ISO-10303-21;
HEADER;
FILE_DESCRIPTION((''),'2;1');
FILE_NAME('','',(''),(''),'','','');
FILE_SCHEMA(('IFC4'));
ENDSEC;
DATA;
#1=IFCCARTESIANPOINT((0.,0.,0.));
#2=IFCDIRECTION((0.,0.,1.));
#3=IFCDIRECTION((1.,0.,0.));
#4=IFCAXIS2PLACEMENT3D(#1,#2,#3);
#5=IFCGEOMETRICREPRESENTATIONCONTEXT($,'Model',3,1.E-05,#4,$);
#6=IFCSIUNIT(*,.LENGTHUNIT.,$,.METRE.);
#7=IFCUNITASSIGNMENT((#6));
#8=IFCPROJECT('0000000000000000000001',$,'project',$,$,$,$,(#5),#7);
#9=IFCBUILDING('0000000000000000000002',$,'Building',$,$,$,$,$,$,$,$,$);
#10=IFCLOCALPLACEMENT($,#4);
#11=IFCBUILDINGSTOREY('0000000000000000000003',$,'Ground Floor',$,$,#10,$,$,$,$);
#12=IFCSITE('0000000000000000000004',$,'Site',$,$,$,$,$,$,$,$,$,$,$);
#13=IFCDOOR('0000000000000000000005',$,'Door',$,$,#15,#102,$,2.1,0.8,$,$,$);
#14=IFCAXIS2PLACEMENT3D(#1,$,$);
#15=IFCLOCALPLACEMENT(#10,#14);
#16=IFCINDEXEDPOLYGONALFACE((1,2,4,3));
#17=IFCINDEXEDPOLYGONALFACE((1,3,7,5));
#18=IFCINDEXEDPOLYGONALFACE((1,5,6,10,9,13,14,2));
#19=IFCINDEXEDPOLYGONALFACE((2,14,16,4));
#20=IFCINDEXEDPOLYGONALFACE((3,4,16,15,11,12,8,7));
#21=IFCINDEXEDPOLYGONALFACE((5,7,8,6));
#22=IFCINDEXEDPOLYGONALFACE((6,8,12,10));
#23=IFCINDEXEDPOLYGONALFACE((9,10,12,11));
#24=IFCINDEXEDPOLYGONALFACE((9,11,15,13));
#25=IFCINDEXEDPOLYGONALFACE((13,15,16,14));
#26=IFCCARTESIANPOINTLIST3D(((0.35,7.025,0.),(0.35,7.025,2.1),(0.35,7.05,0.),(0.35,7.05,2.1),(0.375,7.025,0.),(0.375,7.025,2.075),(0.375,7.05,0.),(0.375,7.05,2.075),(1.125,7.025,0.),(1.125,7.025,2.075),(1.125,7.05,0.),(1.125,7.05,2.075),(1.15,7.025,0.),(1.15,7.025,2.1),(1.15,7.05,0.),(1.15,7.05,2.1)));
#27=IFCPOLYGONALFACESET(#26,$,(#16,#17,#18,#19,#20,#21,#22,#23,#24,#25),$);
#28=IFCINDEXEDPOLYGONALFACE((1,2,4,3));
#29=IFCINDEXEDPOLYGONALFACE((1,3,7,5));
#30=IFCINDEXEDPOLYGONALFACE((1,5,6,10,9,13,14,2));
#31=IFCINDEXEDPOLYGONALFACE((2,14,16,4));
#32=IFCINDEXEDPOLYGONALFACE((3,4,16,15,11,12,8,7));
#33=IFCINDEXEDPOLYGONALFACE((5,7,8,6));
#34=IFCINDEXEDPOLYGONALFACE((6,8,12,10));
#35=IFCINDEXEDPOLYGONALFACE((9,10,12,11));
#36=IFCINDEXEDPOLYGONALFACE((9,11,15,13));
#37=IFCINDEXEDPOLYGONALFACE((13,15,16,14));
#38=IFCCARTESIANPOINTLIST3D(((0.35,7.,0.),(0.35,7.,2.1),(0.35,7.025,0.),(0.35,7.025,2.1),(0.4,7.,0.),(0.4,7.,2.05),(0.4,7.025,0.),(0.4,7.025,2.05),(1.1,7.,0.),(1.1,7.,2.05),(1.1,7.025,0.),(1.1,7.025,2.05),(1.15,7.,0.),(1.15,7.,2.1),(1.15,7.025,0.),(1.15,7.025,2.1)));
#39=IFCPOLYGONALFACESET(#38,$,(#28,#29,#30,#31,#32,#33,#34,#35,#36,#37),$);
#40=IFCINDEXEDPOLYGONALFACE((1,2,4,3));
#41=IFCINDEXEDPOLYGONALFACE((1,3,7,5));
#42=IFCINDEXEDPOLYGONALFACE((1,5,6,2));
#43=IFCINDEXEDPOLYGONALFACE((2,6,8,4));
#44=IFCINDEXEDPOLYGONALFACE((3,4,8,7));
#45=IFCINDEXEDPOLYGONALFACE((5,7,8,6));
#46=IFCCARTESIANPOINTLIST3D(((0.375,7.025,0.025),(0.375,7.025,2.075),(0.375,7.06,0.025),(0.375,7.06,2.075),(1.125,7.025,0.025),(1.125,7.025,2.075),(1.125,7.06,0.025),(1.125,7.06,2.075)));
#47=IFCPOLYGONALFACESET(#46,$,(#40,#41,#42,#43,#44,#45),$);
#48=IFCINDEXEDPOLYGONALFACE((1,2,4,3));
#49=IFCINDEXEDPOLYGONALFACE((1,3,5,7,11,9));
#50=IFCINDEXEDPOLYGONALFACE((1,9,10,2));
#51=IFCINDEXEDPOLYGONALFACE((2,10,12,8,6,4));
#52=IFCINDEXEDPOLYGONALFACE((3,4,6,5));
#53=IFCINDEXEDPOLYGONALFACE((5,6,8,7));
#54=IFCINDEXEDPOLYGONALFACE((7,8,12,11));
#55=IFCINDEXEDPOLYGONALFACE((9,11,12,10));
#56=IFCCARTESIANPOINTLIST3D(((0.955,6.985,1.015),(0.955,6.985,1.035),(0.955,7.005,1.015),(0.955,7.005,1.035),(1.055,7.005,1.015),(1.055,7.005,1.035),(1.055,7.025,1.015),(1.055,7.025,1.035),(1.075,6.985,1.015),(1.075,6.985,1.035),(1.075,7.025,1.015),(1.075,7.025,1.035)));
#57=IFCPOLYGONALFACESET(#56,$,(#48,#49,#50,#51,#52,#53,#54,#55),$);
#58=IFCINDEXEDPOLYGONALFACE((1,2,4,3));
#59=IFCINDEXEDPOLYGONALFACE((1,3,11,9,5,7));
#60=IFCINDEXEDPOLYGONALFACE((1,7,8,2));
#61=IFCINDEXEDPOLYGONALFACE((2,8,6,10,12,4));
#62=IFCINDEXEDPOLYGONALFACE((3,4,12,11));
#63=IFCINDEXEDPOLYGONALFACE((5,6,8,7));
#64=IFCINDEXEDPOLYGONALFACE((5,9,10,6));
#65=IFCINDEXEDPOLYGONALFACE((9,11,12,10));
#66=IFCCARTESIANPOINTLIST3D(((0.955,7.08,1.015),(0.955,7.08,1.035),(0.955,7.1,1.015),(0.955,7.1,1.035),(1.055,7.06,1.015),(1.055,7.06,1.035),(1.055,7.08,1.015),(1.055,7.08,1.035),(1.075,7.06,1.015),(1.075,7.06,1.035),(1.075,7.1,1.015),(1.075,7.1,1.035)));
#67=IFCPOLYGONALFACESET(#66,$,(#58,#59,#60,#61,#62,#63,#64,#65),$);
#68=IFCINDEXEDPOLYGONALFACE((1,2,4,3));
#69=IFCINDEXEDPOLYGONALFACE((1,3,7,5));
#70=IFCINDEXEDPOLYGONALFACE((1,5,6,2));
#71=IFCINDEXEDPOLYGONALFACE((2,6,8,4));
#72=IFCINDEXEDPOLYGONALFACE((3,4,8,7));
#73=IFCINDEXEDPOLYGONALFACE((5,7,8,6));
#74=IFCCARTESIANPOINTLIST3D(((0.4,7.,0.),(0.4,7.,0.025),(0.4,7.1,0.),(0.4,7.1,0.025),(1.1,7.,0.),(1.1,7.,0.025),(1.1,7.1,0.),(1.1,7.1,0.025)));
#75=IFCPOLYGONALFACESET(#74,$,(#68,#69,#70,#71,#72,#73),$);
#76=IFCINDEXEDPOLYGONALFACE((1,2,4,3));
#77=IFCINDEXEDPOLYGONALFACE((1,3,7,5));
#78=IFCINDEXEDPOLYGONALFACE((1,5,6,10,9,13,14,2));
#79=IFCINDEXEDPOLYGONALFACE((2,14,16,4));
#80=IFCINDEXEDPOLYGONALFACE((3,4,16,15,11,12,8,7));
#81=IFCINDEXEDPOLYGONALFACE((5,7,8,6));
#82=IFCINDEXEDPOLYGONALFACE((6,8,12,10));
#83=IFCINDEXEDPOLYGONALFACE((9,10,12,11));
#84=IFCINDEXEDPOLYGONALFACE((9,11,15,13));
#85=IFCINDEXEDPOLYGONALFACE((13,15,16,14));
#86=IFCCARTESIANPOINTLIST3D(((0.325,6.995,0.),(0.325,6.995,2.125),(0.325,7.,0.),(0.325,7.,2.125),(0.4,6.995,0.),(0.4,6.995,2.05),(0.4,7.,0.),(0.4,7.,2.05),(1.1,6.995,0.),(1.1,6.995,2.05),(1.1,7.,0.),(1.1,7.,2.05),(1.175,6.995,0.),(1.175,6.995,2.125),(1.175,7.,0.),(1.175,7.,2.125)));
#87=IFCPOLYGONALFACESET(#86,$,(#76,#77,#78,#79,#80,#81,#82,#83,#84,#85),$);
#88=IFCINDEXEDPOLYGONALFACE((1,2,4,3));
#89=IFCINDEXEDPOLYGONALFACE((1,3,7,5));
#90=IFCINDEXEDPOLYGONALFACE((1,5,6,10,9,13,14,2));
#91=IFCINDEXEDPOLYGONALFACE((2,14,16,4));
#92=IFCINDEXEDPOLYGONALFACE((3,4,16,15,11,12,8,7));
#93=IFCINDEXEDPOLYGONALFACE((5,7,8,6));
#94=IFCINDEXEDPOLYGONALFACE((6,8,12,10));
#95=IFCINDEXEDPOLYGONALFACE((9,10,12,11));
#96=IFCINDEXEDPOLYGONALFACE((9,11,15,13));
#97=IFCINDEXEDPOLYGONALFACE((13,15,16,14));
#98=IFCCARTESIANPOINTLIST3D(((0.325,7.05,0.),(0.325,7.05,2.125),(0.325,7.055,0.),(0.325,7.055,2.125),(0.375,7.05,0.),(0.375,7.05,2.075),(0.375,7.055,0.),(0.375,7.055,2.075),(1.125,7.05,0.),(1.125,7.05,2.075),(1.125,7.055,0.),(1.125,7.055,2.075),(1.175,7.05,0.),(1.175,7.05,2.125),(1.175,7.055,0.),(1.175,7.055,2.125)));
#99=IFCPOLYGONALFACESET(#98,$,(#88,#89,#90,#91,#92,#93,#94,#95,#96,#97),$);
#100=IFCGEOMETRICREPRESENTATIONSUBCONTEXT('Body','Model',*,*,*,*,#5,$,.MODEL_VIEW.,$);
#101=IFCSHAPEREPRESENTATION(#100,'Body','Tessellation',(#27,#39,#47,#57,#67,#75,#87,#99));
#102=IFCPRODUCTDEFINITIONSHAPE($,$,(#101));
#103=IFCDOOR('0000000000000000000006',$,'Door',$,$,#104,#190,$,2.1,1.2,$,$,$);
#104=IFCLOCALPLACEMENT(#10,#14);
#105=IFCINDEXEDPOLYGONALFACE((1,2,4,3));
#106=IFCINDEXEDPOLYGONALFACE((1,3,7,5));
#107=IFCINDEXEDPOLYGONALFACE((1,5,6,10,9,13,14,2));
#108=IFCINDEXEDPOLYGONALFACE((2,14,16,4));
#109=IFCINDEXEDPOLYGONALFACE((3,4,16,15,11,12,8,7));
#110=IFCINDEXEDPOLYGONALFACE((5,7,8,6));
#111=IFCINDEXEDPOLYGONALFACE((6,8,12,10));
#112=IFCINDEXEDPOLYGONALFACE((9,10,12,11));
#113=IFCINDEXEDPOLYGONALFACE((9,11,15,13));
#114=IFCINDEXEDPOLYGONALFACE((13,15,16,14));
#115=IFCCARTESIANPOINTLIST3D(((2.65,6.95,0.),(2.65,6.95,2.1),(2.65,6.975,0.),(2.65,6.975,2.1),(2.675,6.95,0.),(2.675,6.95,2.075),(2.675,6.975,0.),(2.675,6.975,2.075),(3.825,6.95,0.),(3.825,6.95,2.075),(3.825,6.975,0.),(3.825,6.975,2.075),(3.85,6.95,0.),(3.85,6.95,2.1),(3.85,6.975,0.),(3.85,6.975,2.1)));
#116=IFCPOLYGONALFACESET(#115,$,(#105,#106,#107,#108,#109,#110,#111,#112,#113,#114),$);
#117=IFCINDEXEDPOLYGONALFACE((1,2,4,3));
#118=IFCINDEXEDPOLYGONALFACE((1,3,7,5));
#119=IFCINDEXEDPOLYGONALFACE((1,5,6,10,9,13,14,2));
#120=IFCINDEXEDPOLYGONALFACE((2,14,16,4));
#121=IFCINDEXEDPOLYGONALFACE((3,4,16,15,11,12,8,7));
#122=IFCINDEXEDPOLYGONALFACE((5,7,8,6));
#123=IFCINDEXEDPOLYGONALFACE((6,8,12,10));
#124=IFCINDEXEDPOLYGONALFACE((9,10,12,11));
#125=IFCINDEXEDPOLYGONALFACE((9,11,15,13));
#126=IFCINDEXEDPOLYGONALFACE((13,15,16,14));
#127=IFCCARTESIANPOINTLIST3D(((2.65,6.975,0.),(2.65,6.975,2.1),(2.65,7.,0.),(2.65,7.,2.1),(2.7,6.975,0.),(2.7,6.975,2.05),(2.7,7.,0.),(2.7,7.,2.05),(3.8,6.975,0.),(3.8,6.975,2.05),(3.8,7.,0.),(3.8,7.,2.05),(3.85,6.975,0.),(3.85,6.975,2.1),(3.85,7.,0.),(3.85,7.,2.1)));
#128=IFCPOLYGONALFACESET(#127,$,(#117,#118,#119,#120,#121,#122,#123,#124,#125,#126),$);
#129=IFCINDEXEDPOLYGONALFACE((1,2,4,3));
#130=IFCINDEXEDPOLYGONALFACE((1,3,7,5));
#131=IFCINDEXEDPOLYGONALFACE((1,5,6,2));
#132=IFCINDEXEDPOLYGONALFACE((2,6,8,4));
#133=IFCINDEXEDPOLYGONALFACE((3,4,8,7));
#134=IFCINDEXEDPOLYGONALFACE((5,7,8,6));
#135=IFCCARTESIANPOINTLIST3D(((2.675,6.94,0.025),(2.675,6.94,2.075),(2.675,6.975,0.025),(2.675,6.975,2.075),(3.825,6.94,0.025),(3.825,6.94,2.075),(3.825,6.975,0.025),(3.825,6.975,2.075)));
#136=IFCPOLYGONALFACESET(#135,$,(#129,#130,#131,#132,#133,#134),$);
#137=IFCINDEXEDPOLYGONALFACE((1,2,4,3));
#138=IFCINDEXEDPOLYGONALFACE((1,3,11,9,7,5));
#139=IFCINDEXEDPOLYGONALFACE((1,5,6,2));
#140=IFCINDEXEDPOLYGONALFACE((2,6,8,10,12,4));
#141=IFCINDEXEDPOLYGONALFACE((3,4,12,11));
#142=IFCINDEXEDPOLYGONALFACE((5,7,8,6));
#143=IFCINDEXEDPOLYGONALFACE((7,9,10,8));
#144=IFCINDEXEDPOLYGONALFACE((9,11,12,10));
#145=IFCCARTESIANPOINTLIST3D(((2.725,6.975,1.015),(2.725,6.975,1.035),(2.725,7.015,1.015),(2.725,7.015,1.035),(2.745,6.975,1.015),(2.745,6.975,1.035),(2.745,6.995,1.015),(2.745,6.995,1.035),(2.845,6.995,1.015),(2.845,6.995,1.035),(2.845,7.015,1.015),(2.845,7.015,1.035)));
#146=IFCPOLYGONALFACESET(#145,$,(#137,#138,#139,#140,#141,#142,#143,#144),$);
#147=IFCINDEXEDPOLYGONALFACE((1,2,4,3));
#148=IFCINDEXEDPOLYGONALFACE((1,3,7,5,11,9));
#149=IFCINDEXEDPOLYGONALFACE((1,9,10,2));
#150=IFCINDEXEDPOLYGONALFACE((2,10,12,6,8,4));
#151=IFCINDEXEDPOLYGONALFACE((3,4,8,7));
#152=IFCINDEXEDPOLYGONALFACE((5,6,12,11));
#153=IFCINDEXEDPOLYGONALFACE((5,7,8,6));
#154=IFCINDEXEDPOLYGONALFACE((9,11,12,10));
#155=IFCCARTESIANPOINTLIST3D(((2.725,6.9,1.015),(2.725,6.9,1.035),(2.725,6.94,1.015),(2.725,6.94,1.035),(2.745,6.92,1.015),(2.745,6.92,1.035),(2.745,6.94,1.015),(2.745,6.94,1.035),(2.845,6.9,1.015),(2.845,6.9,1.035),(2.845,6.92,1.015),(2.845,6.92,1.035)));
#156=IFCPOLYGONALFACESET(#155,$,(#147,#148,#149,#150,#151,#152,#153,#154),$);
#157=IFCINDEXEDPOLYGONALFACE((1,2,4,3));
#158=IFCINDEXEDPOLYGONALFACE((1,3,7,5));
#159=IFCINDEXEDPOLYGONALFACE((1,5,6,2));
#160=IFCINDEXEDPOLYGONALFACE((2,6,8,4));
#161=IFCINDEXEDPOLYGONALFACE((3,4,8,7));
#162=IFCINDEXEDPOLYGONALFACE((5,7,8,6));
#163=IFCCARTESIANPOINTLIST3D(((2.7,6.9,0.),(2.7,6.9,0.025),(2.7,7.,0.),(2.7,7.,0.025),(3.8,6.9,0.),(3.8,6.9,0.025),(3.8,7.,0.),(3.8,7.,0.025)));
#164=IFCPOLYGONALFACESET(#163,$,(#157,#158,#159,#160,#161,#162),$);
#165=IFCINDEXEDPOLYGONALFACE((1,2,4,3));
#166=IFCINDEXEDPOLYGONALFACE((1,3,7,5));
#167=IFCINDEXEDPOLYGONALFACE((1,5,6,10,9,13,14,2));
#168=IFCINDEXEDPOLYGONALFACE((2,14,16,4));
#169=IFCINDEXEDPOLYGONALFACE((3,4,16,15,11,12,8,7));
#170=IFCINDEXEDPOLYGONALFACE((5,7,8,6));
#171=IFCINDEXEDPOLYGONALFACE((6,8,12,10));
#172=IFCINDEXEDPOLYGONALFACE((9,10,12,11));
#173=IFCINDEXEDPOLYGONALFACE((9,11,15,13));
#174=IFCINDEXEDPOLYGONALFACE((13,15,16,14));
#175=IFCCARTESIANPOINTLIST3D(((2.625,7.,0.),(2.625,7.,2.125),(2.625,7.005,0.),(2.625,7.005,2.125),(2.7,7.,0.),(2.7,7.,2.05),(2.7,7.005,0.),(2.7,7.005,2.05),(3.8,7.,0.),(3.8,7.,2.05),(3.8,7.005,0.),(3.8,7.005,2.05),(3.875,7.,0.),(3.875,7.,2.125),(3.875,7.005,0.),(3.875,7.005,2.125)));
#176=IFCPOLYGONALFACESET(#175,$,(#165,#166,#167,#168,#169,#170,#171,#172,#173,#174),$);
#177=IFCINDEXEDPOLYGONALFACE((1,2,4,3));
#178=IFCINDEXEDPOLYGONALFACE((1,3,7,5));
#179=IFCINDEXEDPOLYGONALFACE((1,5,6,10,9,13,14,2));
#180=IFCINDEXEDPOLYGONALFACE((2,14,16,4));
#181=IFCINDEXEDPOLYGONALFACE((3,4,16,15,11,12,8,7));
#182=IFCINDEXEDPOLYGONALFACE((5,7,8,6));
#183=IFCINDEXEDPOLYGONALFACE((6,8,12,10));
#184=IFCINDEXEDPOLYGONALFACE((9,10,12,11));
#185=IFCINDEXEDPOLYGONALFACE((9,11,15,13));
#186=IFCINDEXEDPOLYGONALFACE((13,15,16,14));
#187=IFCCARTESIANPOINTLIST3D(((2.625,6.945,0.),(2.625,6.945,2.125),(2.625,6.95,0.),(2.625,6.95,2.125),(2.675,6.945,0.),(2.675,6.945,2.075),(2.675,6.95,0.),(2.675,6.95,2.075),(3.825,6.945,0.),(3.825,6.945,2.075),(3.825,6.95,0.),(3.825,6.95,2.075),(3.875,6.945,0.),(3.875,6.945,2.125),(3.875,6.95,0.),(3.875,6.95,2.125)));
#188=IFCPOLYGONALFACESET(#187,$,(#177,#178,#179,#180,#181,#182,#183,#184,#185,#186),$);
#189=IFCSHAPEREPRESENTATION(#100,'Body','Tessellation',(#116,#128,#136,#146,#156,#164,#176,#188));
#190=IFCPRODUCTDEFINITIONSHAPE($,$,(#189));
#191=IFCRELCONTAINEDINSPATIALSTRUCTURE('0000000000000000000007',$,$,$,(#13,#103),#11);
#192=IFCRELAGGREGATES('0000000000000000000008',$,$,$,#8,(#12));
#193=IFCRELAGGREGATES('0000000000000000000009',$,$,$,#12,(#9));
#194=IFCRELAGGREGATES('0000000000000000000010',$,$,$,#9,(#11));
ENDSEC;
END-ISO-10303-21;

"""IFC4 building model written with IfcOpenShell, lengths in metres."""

from ifc_helpers import new_model, si_unit, frame, origin_with_axes, place, context, subcontext, project, spatial, line, indexed_curve, outline, extrude, element, save


model = new_model("IFC4")

# Units and contexts
model_context = context("Model", 3, precision=1e-05, world=origin_with_axes())
body_context = subcontext(model_context, "Body", "Model", "MODEL_VIEW")
ifc_project = project(units=[si_unit("LENGTHUNIT", "METRE")], contexts=[model_context])

# Site, building, storey
site = spatial("IfcSite", under=ifc_project, Name="Site")
building = spatial("IfcBuilding", under=site, Name="Building")
storey_placement = place(None, origin_with_axes())
storey = spatial("IfcBuildingStorey", under=building, at=storey_placement, Name="Ground Floor")

# Doors
door_1_placement = place(storey_placement, frame((0.35, 7.0, 0.0), z_axis=(0.0, 0.0, 1.0), x_axis=(1.0, 0.0, 0.0)))
element("IfcDoor", 1, at=door_1_placement, inside=storey, Name="Door", OverallHeight=2.1, OverallWidth=0.8, context=body_context, shape_type="SweptSolid", body=[
    extrude(outline(indexed_curve([(0.0, 0.0), (0.0, 2.1), (0.8, 2.1), (0.8, 0.0), (0.775, 0.0), (0.775, 2.075), (0.025, 2.075), (0.025, 0.0)], segments=[line(1, 2, 3, 4, 5, 6, 7, 8, 1)])), frame((0.0, 0.025, 0.0), z_axis=(0.0, -1.0, 0.0), x_axis=(1.0, 0.0, 0.0)), (0.0, 0.0, -1.0), 0.025),
    extrude(outline(indexed_curve([(0.0, 0.0), (0.0, 2.1), (0.8, 2.1), (0.8, 0.0), (0.75, 0.0), (0.75, 2.05), (0.05, 2.05), (0.05, 0.0)], segments=[line(1, 2, 3, 4, 5, 6, 7, 8, 1)])), frame((0.0, 0.0, 0.0), z_axis=(0.0, -1.0, 0.0), x_axis=(1.0, 0.0, 0.0)), (0.0, 0.0, -1.0), 0.025),
    extrude(outline(indexed_curve([(0.0, 0.0), (0.75, 0.0), (0.75, 0.035), (0.0, 0.035)], segments=[line(1, 2, 3, 4, 1)])), frame((0.025, 0.025, 0.025), z_axis=(0.0, 0.0, 1.0), x_axis=(1.0, 0.0, 0.0)), (0.0, 0.0, 1.0), 2.05),
    extrude(outline(indexed_curve([(0.0, 0.0), (0.0, -0.04), (-0.12, -0.04), (-0.12, -0.02), (-0.02, -0.02), (-0.02, 0.0)], segments=[line(1, 2, 3, 4, 5, 6, 1)])), frame((0.725, 0.025, 1.015), z_axis=(0.0, 0.0, 1.0), x_axis=(1.0, 0.0, 0.0)), (0.0, 0.0, 1.0), 0.02),
    extrude(outline(indexed_curve([(0.0, 0.0), (0.0, 0.04), (-0.12, 0.04), (-0.12, 0.02), (-0.02, 0.02), (-0.02, 0.0)], segments=[line(1, 2, 3, 4, 5, 6, 1)])), frame((0.725, 0.06, 1.015), z_axis=(0.0, 0.0, 1.0), x_axis=(1.0, 0.0, 0.0)), (0.0, 0.0, 1.0), 0.02),
    extrude(outline(indexed_curve([(0.0, 0.0), (0.7, 0.0), (0.7, 0.1), (0.0, 0.1)], segments=[line(1, 2, 3, 4, 1)])), frame((0.05, 0.0, 0.0), z_axis=(0.0, 0.0, 1.0), x_axis=(1.0, 0.0, 0.0)), (0.0, 0.0, 1.0), 0.025),
    extrude(outline(indexed_curve([(0.0, 0.0), (0.0, 2.125), (0.85, 2.125), (0.85, 0.0), (0.775, 0.0), (0.775, 2.05), (0.075, 2.05), (0.075, 0.0)], segments=[line(1, 2, 3, 4, 5, 6, 7, 8, 1)])), frame((-0.025, -0.005, 0.0), z_axis=(0.0, -1.0, 0.0), x_axis=(1.0, 0.0, 0.0)), (0.0, 0.0, -1.0), 0.005),
    extrude(outline(indexed_curve([(0.0, 0.0), (0.0, 2.125), (0.85, 2.125), (0.85, 0.0), (0.8, 0.0), (0.8, 2.075), (0.05, 2.075), (0.05, 0.0)], segments=[line(1, 2, 3, 4, 5, 6, 7, 8, 1)])), frame((-0.025, 0.05, 0.0), z_axis=(0.0, -1.0, 0.0), x_axis=(1.0, 0.0, 0.0)), (0.0, 0.0, -1.0), 0.005),
])
door_2_placement = place(storey_placement, frame((3.85, 7.0, 0.0), z_axis=(0.0, 0.0, 1.0), x_axis=(-1.0, 0.0, 0.0)))
element("IfcDoor", 2, at=door_2_placement, inside=storey, Name="Door", OverallHeight=2.1, OverallWidth=1.2, context=body_context, shape_type="SweptSolid", body=[
    extrude(outline(indexed_curve([(0.0, 0.0), (0.0, 2.1), (1.2, 2.1), (1.2, 0.0), (1.175, 0.0), (1.175, 2.075), (0.025, 2.075), (0.025, 0.0)], segments=[line(1, 2, 3, 4, 5, 6, 7, 8, 1)])), frame((0.0, 0.025, 0.0), z_axis=(0.0, -1.0, 0.0), x_axis=(1.0, 0.0, 0.0)), (0.0, 0.0, -1.0), 0.025),
    extrude(outline(indexed_curve([(0.0, 0.0), (0.0, 2.1), (1.2, 2.1), (1.2, 0.0), (1.15, 0.0), (1.15, 2.05), (0.05, 2.05), (0.05, 0.0)], segments=[line(1, 2, 3, 4, 5, 6, 7, 8, 1)])), frame((0.0, 0.0, 0.0), z_axis=(0.0, -1.0, 0.0), x_axis=(1.0, 0.0, 0.0)), (0.0, 0.0, -1.0), 0.025),
    extrude(outline(indexed_curve([(0.0, 0.0), (1.15, 0.0), (1.15, 0.035), (0.0, 0.035)], segments=[line(1, 2, 3, 4, 1)])), frame((0.025, 0.025, 0.025), z_axis=(0.0, 0.0, 1.0), x_axis=(1.0, 0.0, 0.0)), (0.0, 0.0, 1.0), 2.05),
    extrude(outline(indexed_curve([(0.0, 0.0), (0.0, -0.04), (-0.12, -0.04), (-0.12, -0.02), (-0.02, -0.02), (-0.02, 0.0)], segments=[line(1, 2, 3, 4, 5, 6, 1)])), frame((1.125, 0.025, 1.015), z_axis=(0.0, 0.0, 1.0), x_axis=(1.0, 0.0, 0.0)), (0.0, 0.0, 1.0), 0.02),
    extrude(outline(indexed_curve([(0.0, 0.0), (0.0, 0.04), (-0.12, 0.04), (-0.12, 0.02), (-0.02, 0.02), (-0.02, 0.0)], segments=[line(1, 2, 3, 4, 5, 6, 1)])), frame((1.125, 0.06, 1.015), z_axis=(0.0, 0.0, 1.0), x_axis=(1.0, 0.0, 0.0)), (0.0, 0.0, 1.0), 0.02),
    extrude(outline(indexed_curve([(0.0, 0.0), (1.1, 0.0), (1.1, 0.1), (0.0, 0.1)], segments=[line(1, 2, 3, 4, 1)])), frame((0.05, 0.0, 0.0), z_axis=(0.0, 0.0, 1.0), x_axis=(1.0, 0.0, 0.0)), (0.0, 0.0, 1.0), 0.025),
    extrude(outline(indexed_curve([(0.0, 0.0), (0.0, 2.125), (1.25, 2.125), (1.25, 0.0), (1.175, 0.0), (1.175, 2.05), (0.075, 2.05), (0.075, 0.0)], segments=[line(1, 2, 3, 4, 5, 6, 7, 8, 1)])), frame((-0.025, -0.005, 0.0), z_axis=(0.0, -1.0, 0.0), x_axis=(1.0, 0.0, 0.0)), (0.0, 0.0, -1.0), 0.005),
    extrude(outline(indexed_curve([(0.0, 0.0), (0.0, 2.125), (1.25, 2.125), (1.25, 0.0), (1.2, 0.0), (1.2, 2.075), (0.05, 2.075), (0.05, 0.0)], segments=[line(1, 2, 3, 4, 5, 6, 7, 8, 1)])), frame((-0.025, 0.05, 0.0), z_axis=(0.0, -1.0, 0.0), x_axis=(1.0, 0.0, 0.0)), (0.0, 0.0, -1.0), 0.005),
])

save(model, "model.ifc")
